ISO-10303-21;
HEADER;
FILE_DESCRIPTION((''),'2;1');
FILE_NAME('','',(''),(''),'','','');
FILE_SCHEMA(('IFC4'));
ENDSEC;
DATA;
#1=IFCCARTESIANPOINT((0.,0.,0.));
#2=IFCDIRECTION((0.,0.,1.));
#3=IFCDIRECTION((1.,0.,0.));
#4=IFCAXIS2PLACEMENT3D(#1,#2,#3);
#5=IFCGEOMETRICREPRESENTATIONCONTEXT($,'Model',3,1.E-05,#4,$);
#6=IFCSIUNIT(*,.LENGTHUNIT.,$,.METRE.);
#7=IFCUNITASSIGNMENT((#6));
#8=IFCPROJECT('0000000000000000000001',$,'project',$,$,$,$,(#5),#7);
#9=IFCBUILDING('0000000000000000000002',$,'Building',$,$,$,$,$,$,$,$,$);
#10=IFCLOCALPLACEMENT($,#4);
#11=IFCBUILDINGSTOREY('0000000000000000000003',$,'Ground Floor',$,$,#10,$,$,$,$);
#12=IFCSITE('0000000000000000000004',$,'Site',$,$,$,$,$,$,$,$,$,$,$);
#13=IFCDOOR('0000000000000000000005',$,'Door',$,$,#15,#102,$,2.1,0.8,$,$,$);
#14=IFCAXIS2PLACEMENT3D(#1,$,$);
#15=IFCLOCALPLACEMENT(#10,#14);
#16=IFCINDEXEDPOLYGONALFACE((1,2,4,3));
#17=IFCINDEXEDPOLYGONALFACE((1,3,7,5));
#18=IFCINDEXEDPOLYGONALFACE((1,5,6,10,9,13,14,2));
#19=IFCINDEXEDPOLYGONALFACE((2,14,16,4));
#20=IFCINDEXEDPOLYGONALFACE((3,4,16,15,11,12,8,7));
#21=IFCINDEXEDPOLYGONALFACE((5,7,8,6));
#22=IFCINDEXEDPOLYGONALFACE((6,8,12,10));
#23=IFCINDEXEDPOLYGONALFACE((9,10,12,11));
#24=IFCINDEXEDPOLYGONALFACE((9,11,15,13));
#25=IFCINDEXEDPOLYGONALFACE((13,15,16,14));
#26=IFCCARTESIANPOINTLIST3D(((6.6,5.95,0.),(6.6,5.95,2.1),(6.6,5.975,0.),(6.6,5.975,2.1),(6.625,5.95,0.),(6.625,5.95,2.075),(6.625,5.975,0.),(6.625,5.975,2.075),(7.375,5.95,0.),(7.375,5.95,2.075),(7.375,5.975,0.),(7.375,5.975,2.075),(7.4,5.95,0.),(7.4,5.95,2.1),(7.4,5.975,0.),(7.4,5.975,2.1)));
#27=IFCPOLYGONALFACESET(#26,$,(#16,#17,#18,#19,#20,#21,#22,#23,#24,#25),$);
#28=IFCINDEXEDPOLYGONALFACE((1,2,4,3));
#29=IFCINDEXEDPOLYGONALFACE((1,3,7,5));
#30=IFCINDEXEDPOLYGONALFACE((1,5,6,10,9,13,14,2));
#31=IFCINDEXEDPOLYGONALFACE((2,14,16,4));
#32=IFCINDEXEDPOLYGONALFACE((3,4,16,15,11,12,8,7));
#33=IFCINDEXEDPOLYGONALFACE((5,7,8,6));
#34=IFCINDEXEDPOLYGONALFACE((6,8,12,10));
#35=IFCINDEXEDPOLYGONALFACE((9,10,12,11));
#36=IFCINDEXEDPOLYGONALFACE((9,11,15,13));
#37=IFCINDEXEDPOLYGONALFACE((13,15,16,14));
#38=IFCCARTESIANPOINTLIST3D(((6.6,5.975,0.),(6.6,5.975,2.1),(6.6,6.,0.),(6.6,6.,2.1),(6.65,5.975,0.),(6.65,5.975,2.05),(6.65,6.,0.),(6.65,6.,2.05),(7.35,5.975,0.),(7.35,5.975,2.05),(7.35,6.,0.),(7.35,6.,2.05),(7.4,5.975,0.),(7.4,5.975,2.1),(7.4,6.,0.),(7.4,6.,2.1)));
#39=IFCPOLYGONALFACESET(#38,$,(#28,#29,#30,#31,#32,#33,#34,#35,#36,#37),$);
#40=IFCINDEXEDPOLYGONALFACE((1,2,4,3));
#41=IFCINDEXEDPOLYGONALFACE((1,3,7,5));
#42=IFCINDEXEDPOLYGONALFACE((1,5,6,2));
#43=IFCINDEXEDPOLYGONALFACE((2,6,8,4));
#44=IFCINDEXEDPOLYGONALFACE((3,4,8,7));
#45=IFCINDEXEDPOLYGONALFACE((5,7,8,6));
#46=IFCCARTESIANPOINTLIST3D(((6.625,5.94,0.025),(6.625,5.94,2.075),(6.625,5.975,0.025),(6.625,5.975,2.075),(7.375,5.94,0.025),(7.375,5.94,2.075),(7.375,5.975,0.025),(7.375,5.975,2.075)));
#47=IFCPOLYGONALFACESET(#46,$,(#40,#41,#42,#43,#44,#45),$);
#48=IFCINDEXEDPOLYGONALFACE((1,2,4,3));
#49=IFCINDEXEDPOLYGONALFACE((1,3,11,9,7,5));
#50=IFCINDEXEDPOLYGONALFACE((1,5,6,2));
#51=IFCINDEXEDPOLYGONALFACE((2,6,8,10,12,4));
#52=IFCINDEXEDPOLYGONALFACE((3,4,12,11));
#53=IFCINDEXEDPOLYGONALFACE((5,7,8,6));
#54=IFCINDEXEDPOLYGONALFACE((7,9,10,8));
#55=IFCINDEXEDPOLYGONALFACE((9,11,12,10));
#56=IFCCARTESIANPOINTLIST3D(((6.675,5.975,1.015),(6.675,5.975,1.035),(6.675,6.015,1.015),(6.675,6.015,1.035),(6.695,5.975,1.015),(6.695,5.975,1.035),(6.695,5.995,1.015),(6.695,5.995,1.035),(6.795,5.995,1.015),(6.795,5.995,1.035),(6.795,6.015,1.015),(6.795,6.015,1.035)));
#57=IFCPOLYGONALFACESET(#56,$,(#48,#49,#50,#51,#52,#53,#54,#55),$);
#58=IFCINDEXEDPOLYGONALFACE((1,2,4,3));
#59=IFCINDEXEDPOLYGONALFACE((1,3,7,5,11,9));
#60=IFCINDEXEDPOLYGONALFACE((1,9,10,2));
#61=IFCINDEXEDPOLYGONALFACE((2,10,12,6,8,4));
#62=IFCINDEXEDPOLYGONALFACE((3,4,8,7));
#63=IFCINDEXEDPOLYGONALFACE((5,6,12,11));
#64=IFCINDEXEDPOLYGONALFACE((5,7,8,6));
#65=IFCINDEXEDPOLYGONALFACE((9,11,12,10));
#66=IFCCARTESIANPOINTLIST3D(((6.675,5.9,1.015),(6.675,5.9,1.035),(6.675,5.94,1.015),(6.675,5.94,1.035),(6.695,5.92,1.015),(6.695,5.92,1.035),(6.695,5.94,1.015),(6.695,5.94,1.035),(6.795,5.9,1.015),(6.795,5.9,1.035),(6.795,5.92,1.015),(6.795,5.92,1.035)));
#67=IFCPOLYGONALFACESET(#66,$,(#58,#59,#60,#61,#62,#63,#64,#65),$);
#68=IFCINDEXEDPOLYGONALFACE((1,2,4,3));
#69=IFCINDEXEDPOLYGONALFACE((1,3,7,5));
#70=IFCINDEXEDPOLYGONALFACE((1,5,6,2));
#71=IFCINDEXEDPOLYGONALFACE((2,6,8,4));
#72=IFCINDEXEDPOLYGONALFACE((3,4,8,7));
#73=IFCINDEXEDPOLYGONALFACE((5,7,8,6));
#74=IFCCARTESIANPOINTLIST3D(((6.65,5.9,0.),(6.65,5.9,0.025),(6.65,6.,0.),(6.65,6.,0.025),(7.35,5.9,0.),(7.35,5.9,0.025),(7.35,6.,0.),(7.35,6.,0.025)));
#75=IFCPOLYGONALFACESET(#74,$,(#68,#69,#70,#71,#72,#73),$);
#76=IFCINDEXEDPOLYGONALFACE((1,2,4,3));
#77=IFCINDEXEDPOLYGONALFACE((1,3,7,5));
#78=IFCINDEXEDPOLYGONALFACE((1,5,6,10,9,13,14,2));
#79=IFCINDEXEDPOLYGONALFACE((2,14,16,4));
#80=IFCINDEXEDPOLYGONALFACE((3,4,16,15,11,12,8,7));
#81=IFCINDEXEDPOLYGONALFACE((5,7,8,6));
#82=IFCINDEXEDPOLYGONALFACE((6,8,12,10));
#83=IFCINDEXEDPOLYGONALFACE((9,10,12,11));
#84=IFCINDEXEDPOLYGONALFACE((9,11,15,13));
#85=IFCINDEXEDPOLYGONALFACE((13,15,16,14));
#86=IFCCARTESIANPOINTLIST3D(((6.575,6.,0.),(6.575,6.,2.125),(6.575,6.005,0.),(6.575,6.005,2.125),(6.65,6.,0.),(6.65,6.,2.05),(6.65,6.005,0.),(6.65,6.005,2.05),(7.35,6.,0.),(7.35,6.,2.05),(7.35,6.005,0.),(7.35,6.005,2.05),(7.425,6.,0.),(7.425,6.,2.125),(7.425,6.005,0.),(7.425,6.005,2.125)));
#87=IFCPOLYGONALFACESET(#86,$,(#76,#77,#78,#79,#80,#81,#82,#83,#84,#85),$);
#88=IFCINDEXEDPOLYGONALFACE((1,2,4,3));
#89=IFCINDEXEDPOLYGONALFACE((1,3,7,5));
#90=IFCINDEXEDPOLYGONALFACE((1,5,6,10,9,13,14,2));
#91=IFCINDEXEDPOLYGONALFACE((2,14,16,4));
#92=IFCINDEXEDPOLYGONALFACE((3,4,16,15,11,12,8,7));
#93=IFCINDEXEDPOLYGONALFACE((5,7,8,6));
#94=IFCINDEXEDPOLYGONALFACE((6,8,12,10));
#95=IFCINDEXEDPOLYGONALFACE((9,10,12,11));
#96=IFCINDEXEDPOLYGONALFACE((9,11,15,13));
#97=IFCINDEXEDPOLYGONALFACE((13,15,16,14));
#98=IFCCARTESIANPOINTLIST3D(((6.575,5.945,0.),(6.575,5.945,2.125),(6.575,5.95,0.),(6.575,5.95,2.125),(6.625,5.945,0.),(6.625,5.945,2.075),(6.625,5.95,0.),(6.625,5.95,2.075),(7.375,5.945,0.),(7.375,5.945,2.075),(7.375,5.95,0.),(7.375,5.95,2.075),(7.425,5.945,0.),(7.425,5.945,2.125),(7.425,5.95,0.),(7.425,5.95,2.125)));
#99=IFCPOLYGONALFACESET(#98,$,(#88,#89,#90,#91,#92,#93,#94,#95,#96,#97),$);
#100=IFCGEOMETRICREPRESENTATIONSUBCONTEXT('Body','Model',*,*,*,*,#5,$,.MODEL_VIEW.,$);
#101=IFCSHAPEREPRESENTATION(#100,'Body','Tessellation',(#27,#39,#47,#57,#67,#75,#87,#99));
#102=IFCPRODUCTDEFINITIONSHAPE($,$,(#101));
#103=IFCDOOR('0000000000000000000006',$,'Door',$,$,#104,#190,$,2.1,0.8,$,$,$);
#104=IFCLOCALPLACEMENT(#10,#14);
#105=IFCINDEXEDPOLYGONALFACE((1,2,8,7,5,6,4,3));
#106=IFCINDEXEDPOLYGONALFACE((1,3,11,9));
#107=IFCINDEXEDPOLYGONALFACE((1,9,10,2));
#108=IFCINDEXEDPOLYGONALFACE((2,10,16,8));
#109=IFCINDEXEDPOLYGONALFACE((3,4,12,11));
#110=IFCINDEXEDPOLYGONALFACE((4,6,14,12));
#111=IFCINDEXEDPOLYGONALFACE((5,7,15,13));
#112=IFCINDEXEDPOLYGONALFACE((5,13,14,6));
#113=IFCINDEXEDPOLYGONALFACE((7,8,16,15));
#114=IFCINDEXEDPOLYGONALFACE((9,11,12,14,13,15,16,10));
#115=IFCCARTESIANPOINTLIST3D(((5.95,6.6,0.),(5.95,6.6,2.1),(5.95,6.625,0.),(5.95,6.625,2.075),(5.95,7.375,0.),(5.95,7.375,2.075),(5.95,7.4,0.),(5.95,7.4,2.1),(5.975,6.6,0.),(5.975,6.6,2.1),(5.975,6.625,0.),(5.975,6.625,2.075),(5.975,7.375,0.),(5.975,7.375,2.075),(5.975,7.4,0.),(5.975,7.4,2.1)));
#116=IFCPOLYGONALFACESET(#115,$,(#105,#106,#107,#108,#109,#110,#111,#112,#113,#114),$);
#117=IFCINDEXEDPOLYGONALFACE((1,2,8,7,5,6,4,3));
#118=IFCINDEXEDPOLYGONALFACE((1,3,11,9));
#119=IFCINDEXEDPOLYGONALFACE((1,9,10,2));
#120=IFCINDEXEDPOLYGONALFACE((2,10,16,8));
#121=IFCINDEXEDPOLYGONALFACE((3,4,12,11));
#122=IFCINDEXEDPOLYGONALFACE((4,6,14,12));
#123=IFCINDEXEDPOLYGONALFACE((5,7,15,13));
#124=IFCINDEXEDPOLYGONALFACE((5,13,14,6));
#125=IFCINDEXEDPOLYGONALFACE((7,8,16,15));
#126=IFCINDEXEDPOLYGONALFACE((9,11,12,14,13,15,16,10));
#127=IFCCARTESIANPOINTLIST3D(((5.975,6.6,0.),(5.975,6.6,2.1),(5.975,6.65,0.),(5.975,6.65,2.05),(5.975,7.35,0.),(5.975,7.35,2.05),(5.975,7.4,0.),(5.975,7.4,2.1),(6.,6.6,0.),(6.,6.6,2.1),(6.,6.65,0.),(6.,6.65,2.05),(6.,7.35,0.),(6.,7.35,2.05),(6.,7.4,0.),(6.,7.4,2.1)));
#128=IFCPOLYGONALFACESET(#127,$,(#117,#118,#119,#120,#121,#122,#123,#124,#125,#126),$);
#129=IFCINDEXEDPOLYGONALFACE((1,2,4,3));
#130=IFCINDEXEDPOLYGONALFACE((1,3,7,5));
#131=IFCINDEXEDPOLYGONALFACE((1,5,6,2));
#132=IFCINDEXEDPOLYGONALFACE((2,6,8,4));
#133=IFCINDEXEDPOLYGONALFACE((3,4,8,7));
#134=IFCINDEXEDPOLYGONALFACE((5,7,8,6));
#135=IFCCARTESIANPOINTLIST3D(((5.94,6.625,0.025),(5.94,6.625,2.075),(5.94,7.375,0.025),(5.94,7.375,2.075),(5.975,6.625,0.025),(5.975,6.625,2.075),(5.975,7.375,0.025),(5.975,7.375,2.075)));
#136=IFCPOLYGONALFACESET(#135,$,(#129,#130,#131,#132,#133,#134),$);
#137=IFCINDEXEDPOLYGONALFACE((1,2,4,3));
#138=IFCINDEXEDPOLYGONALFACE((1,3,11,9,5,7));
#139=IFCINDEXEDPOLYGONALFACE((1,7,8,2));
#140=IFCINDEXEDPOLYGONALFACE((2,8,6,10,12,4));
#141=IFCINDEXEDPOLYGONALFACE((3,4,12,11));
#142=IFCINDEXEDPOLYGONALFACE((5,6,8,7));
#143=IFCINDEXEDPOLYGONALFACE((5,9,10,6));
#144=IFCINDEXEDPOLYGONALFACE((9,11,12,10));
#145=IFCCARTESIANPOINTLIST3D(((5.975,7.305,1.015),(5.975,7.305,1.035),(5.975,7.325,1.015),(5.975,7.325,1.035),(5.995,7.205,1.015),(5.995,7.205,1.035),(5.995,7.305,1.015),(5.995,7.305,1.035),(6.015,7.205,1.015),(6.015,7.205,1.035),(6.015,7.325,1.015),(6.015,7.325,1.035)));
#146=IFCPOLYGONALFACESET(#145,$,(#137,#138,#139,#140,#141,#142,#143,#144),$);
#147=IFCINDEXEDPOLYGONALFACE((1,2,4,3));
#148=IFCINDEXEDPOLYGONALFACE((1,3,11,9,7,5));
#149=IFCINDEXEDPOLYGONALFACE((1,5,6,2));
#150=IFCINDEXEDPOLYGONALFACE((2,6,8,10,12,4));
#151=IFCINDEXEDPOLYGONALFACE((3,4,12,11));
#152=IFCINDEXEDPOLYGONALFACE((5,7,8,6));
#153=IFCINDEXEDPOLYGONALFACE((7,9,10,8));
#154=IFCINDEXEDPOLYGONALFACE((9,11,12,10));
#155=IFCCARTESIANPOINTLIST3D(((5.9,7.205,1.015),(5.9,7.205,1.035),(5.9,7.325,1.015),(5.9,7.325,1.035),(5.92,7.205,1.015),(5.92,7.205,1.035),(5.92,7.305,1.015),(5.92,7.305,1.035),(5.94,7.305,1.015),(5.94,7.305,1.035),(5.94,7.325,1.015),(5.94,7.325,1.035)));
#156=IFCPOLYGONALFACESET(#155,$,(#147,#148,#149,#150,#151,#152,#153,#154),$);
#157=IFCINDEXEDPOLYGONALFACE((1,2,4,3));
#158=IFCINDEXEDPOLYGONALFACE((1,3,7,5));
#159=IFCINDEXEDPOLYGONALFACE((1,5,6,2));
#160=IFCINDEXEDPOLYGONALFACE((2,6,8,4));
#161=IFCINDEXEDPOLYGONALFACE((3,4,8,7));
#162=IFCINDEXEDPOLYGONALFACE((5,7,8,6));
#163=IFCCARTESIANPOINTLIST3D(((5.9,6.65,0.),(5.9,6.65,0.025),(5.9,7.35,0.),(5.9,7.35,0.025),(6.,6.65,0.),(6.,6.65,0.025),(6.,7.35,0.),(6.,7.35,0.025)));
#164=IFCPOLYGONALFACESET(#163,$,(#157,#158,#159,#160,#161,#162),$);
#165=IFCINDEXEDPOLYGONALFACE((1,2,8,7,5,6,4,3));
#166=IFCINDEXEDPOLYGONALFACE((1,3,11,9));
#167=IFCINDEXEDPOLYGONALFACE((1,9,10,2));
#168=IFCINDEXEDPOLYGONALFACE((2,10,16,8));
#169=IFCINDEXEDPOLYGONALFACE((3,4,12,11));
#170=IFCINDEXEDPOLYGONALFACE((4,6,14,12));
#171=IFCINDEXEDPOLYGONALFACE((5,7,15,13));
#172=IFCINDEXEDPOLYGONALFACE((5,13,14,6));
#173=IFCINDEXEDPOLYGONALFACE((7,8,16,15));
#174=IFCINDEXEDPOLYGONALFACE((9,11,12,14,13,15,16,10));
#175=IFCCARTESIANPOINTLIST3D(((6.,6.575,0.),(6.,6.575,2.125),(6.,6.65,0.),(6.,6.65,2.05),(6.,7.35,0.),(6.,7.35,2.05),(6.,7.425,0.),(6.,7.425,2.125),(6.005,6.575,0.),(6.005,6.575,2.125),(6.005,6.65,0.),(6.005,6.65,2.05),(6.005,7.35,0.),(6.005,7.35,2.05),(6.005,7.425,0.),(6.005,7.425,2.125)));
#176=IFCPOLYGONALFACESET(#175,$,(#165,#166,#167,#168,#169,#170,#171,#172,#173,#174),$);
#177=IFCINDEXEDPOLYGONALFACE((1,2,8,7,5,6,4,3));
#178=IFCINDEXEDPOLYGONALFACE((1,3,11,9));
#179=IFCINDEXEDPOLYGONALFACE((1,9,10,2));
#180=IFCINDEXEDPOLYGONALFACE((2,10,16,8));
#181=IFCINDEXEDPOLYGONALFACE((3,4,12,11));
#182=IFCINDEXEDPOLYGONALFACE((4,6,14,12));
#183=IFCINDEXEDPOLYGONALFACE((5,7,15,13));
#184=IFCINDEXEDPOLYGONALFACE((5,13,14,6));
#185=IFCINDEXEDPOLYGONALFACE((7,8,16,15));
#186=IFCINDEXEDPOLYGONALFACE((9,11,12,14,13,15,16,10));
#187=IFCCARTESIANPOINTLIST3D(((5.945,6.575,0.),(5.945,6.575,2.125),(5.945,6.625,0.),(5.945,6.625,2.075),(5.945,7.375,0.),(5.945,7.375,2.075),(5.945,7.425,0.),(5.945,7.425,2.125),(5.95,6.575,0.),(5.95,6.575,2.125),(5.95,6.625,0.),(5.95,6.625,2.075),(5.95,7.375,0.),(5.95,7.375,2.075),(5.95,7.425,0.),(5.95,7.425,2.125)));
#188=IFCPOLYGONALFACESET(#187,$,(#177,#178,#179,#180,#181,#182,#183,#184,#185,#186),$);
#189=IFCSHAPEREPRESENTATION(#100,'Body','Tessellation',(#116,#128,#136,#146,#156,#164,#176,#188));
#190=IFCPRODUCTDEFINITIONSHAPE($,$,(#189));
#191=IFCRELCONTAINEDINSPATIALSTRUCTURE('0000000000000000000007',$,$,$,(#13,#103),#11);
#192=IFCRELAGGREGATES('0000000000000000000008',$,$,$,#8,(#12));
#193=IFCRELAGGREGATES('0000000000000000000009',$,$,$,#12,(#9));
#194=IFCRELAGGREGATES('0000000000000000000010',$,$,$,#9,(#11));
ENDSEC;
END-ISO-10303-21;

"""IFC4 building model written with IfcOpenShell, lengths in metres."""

from ifc_helpers import new_model, si_unit, frame, origin_with_axes, place, context, subcontext, project, spatial, line, indexed_curve, outline, extrude, element, save


model = new_model("IFC4")

# Units and contexts
model_context = context("Model", 3, precision=1e-05, world=origin_with_axes())
body_context = subcontext(model_context, "Body", "Model", "MODEL_VIEW")
ifc_project = project(units=[si_unit("LENGTHUNIT", "METRE")], contexts=[model_context])

# Site, building, storey
site = spatial("IfcSite", under=ifc_project, Name="Site")
building = spatial("IfcBuilding", under=site, Name="Building")
storey_placement = place(None, origin_with_axes())
storey = spatial("IfcBuildingStorey", under=building, at=storey_placement, Name="Ground Floor")

# Doors
door_1_placement = place(storey_placement, frame((7.4, 6.0, 0.0), z_axis=(0.0, 0.0, 1.0), x_axis=(-1.0, 0.0, 0.0)))
element("IfcDoor", 1, at=door_1_placement, inside=storey, Name="Door", OverallHeight=2.1, OverallWidth=0.8, context=body_context, shape_type="SweptSolid", body=[
    extrude(outline(indexed_curve([(0.0, 0.0), (0.0, 2.1), (0.8, 2.1), (0.8, 0.0), (0.775, 0.0), (0.775, 2.075), (0.025, 2.075), (0.025, 0.0)], segments=[line(1, 2, 3, 4, 5, 6, 7, 8, 1)])), frame((0.0, 0.025, 0.0), z_axis=(0.0, -1.0, 0.0), x_axis=(1.0, 0.0, 0.0)), (0.0, 0.0, -1.0), 0.025),
    extrude(outline(indexed_curve([(0.0, 0.0), (0.0, 2.1), (0.8, 2.1), (0.8, 0.0), (0.75, 0.0), (0.75, 2.05), (0.05, 2.05), (0.05, 0.0)], segments=[line(1, 2, 3, 4, 5, 6, 7, 8, 1)])), frame((0.0, 0.0, 0.0), z_axis=(0.0, -1.0, 0.0), x_axis=(1.0, 0.0, 0.0)), (0.0, 0.0, -1.0), 0.025),
    extrude(outline(indexed_curve([(0.0, 0.0), (0.75, 0.0), (0.75, 0.035), (0.0, 0.035)], segments=[line(1, 2, 3, 4, 1)])), frame((0.025, 0.025, 0.025), z_axis=(0.0, 0.0, 1.0), x_axis=(1.0, 0.0, 0.0)), (0.0, 0.0, 1.0), 2.05),
    extrude(outline(indexed_curve([(0.0, 0.0), (0.0, -0.04), (-0.12, -0.04), (-0.12, -0.02), (-0.02, -0.02), (-0.02, 0.0)], segments=[line(1, 2, 3, 4, 5, 6, 1)])), frame((0.725, 0.025, 1.015), z_axis=(0.0, 0.0, 1.0), x_axis=(1.0, 0.0, 0.0)), (0.0, 0.0, 1.0), 0.02),
    extrude(outline(indexed_curve([(0.0, 0.0), (0.0, 0.04), (-0.12, 0.04), (-0.12, 0.02), (-0.02, 0.02), (-0.02, 0.0)], segments=[line(1, 2, 3, 4, 5, 6, 1)])), frame((0.725, 0.06, 1.015), z_axis=(0.0, 0.0, 1.0), x_axis=(1.0, 0.0, 0.0)), (0.0, 0.0, 1.0), 0.02),
    extrude(outline(indexed_curve([(0.0, 0.0), (0.7, 0.0), (0.7, 0.1), (0.0, 0.1)], segments=[line(1, 2, 3, 4, 1)])), frame((0.05, 0.0, 0.0), z_axis=(0.0, 0.0, 1.0), x_axis=(1.0, 0.0, 0.0)), (0.0, 0.0, 1.0), 0.025),
    extrude(outline(indexed_curve([(0.0, 0.0), (0.0, 2.125), (0.85, 2.125), (0.85, 0.0), (0.775, 0.0), (0.775, 2.05), (0.075, 2.05), (0.075, 0.0)], segments=[line(1, 2, 3, 4, 5, 6, 7, 8, 1)])), frame((-0.025, -0.005, 0.0), z_axis=(0.0, -1.0, 0.0), x_axis=(1.0, 0.0, 0.0)), (0.0, 0.0, -1.0), 0.005),
    extrude(outline(indexed_curve([(0.0, 0.0), (0.0, 2.125), (0.85, 2.125), (0.85, 0.0), (0.8, 0.0), (0.8, 2.075), (0.05, 2.075), (0.05, 0.0)], segments=[line(1, 2, 3, 4, 5, 6, 7, 8, 1)])), frame((-0.025, 0.05, 0.0), z_axis=(0.0, -1.0, 0.0), x_axis=(1.0, 0.0, 0.0)), (0.0, 0.0, -1.0), 0.005),
])
door_2_placement = place(storey_placement, frame((6.0, 6.6, 0.0), z_axis=(0.0, 0.0, 1.0), x_axis=(0.0, 1.0, 0.0)))
element("IfcDoor", 2, at=door_2_placement, inside=storey, Name="Door", OverallHeight=2.1, OverallWidth=0.8, context=body_context, shape_type="SweptSolid", body=[
    extrude(outline(indexed_curve([(0.0, 0.0), (0.0, 2.1), (0.8, 2.1), (0.8, 0.0), (0.775, 0.0), (0.775, 2.075), (0.025, 2.075), (0.025, 0.0)], segments=[line(1, 2, 3, 4, 5, 6, 7, 8, 1)])), frame((0.0, 0.025, 0.0), z_axis=(0.0, -1.0, 0.0), x_axis=(1.0, 0.0, 0.0)), (0.0, 0.0, -1.0), 0.025),
    extrude(outline(indexed_curve([(0.0, 0.0), (0.0, 2.1), (0.8, 2.1), (0.8, 0.0), (0.75, 0.0), (0.75, 2.05), (0.05, 2.05), (0.05, 0.0)], segments=[line(1, 2, 3, 4, 5, 6, 7, 8, 1)])), frame((0.0, 0.0, 0.0), z_axis=(0.0, -1.0, 0.0), x_axis=(1.0, 0.0, 0.0)), (0.0, 0.0, -1.0), 0.025),
    extrude(outline(indexed_curve([(0.0, 0.0), (0.75, 0.0), (0.75, 0.035), (0.0, 0.035)], segments=[line(1, 2, 3, 4, 1)])), frame((0.025, 0.025, 0.025), z_axis=(0.0, 0.0, 1.0), x_axis=(1.0, 0.0, 0.0)), (0.0, 0.0, 1.0), 2.05),
    extrude(outline(indexed_curve([(0.0, 0.0), (0.0, -0.04), (-0.12, -0.04), (-0.12, -0.02), (-0.02, -0.02), (-0.02, 0.0)], segments=[line(1, 2, 3, 4, 5, 6, 1)])), frame((0.725, 0.025, 1.015), z_axis=(0.0, 0.0, 1.0), x_axis=(1.0, 0.0, 0.0)), (0.0, 0.0, 1.0), 0.02),
    extrude(outline(indexed_curve([(0.0, 0.0), (0.0, 0.04), (-0.12, 0.04), (-0.12, 0.02), (-0.02, 0.02), (-0.02, 0.0)], segments=[line(1, 2, 3, 4, 5, 6, 1)])), frame((0.725, 0.06, 1.015), z_axis=(0.0, 0.0, 1.0), x_axis=(1.0, 0.0, 0.0)), (0.0, 0.0, 1.0), 0.02),
    extrude(outline(indexed_curve([(0.0, 0.0), (0.7, 0.0), (0.7, 0.1), (0.0, 0.1)], segments=[line(1, 2, 3, 4, 1)])), frame((0.05, 0.0, 0.0), z_axis=(0.0, 0.0, 1.0), x_axis=(1.0, 0.0, 0.0)), (0.0, 0.0, 1.0), 0.025),
    extrude(outline(indexed_curve([(0.0, 0.0), (0.0, 2.125), (0.85, 2.125), (0.85, 0.0), (0.775, 0.0), (0.775, 2.05), (0.075, 2.05), (0.075, 0.0)], segments=[line(1, 2, 3, 4, 5, 6, 7, 8, 1)])), frame((-0.025, -0.005, 0.0), z_axis=(0.0, -1.0, 0.0), x_axis=(1.0, 0.0, 0.0)), (0.0, 0.0, -1.0), 0.005),
    extrude(outline(indexed_curve([(0.0, 0.0), (0.0, 2.125), (0.85, 2.125), (0.85, 0.0), (0.8, 0.0), (0.8, 2.075), (0.05, 2.075), (0.05, 0.0)], segments=[line(1, 2, 3, 4, 5, 6, 7, 8, 1)])), frame((-0.025, 0.05, 0.0), z_axis=(0.0, -1.0, 0.0), x_axis=(1.0, 0.0, 0.0)), (0.0, 0.0, -1.0), 0.005),
])

save(model, "model.ifc")
